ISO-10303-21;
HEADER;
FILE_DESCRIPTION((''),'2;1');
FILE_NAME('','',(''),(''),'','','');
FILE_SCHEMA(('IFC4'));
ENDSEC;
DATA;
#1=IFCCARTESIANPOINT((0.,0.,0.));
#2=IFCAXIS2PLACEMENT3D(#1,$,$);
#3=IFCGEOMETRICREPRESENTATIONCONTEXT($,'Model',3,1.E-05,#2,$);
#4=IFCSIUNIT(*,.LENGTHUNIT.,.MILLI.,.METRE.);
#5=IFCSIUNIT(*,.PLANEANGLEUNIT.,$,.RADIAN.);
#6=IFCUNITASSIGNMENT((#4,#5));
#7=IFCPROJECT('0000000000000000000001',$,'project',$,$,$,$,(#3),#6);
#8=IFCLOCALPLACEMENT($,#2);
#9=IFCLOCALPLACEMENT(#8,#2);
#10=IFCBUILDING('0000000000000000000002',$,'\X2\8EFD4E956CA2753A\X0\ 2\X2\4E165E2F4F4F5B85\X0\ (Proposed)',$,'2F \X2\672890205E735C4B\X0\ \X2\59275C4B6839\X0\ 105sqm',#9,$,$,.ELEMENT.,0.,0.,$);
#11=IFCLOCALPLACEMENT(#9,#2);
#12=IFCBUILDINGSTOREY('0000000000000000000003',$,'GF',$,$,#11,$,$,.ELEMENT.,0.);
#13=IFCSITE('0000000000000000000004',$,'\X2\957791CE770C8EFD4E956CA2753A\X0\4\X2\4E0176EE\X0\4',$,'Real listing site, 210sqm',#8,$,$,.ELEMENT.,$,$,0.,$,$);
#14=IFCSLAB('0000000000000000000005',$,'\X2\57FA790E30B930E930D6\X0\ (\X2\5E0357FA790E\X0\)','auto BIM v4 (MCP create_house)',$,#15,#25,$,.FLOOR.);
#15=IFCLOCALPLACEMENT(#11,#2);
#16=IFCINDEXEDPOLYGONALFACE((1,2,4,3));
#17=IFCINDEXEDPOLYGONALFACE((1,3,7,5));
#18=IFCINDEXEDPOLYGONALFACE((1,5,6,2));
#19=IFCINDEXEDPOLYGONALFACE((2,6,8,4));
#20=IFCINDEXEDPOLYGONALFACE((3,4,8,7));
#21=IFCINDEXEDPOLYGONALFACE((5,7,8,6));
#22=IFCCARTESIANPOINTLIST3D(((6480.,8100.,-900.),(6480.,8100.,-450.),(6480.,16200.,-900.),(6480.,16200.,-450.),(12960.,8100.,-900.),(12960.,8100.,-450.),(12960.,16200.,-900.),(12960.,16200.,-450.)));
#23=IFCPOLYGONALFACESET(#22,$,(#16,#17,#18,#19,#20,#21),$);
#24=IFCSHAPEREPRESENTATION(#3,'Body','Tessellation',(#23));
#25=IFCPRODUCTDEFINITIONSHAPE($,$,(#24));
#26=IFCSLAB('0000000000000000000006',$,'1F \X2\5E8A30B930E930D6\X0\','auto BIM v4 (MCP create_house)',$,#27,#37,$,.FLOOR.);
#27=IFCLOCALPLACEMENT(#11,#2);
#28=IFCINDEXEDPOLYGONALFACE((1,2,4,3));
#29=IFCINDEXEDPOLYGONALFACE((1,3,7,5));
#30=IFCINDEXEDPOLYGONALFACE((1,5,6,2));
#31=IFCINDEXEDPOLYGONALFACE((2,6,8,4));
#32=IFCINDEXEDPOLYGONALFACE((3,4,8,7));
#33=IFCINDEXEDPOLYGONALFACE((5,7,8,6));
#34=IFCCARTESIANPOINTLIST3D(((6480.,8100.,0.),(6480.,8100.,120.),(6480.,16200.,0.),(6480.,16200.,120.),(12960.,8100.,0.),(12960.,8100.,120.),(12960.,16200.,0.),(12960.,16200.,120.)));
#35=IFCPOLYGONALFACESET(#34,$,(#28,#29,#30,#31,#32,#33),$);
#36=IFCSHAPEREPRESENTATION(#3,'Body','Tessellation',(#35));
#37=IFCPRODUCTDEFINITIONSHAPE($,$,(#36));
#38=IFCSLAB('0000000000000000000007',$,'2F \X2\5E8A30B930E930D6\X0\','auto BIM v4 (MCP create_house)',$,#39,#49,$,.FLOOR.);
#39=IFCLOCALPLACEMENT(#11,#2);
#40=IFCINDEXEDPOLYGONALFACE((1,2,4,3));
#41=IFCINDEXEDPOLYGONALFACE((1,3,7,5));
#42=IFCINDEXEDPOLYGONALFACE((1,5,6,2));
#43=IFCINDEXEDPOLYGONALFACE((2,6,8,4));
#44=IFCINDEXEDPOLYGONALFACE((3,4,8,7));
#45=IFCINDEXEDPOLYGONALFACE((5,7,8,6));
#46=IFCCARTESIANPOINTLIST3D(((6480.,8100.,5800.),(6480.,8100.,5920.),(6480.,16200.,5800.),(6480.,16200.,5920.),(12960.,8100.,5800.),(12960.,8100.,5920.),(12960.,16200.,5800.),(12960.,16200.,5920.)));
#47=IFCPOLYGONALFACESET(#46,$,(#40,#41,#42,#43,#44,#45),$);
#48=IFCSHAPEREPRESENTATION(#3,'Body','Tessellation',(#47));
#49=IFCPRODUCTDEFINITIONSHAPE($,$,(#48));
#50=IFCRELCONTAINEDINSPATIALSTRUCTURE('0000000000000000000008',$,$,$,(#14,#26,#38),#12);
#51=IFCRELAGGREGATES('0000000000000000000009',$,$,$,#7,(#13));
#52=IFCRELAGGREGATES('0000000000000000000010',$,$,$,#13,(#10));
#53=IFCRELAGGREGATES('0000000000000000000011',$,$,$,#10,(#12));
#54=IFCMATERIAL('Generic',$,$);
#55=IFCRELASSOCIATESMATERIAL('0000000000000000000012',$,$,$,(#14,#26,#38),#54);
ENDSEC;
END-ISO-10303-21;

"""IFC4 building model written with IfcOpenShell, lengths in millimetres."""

from ifc_helpers import new_model, si_unit, frame, frame_2d, origin, place, context, project, spatial, rectangle, extrude, material, element, save


model = new_model("IFC4")

# Units and contexts
model_context = context("Model", 3, precision=1e-05, world=origin())
ifc_project = project(units=[si_unit("LENGTHUNIT", "METRE", prefix="MILLI"), si_unit("PLANEANGLEUNIT", "RADIAN")], contexts=[model_context])

# Site, building, storey
site_placement = place(None, origin())
site = spatial("IfcSite", under=ifc_project, at=site_placement, Name="長野県軽井沢町4丁目4", ObjectType="Real listing site, 210sqm", CompositionType="ELEMENT", RefElevation=0.0)
building_placement = place(site_placement, origin())
building = spatial("IfcBuilding", under=site, at=building_placement, Name="軽井沢町 2世帯住宅 (Proposed)", ObjectType="2F 木造平屋 大屋根 105sqm", CompositionType="ELEMENT", ElevationOfRefHeight=0.0, ElevationOfTerrain=0.0)
storey_placement = place(building_placement, origin())
storey = spatial("IfcBuildingStorey", under=building, at=storey_placement, Name="GF", CompositionType="ELEMENT", Elevation=0.0)

# Slabs
ifc_material = material(Name="Generic")
slab_1_placement = place(storey_placement, frame((3240.0, 4050.0, -450.0)))
element("IfcSlab", 1, at=slab_1_placement, inside=storey, material=ifc_material, Name="基礎スラブ (布基礎)", Description="auto BIM v4 (MCP create_house)", PredefinedType="FLOOR", context=model_context, shape_type="SweptSolid", body=[
    extrude(rectangle(XDim=6480.0, YDim=8100.0, at=frame_2d((3240.0, 4050.0))), frame((3240.0, 4050.0, -450.0)), (0.0, 0.0, 1.0), 450.0),
])
slab_2_placement = place(storey_placement, frame((3240.0, 4050.0, 0.0)))
element("IfcSlab", 2, at=slab_2_placement, inside=storey, material=ifc_material, Name="1F 床スラブ", Description="auto BIM v4 (MCP create_house)", PredefinedType="FLOOR", context=model_context, shape_type="SweptSolid", body=[
    extrude(rectangle(XDim=6480.0, YDim=8100.0, at=frame_2d((3240.0, 4050.0))), frame((3240.0, 4050.0, 0.0)), (0.0, 0.0, 1.0), 120.0),
])
slab_3_placement = place(storey_placement, frame((3240.0, 4050.0, 2900.0)))
element("IfcSlab", 3, at=slab_3_placement, inside=storey, material=ifc_material, Name="2F 床スラブ", Description="auto BIM v4 (MCP create_house)", PredefinedType="FLOOR", context=model_context, shape_type="SweptSolid", body=[
    extrude(rectangle(XDim=6480.0, YDim=8100.0, at=frame_2d((3240.0, 4050.0))), frame((3240.0, 4050.0, 2900.0)), (0.0, 0.0, 1.0), 120.0),
])

save(model, "model.ifc")
